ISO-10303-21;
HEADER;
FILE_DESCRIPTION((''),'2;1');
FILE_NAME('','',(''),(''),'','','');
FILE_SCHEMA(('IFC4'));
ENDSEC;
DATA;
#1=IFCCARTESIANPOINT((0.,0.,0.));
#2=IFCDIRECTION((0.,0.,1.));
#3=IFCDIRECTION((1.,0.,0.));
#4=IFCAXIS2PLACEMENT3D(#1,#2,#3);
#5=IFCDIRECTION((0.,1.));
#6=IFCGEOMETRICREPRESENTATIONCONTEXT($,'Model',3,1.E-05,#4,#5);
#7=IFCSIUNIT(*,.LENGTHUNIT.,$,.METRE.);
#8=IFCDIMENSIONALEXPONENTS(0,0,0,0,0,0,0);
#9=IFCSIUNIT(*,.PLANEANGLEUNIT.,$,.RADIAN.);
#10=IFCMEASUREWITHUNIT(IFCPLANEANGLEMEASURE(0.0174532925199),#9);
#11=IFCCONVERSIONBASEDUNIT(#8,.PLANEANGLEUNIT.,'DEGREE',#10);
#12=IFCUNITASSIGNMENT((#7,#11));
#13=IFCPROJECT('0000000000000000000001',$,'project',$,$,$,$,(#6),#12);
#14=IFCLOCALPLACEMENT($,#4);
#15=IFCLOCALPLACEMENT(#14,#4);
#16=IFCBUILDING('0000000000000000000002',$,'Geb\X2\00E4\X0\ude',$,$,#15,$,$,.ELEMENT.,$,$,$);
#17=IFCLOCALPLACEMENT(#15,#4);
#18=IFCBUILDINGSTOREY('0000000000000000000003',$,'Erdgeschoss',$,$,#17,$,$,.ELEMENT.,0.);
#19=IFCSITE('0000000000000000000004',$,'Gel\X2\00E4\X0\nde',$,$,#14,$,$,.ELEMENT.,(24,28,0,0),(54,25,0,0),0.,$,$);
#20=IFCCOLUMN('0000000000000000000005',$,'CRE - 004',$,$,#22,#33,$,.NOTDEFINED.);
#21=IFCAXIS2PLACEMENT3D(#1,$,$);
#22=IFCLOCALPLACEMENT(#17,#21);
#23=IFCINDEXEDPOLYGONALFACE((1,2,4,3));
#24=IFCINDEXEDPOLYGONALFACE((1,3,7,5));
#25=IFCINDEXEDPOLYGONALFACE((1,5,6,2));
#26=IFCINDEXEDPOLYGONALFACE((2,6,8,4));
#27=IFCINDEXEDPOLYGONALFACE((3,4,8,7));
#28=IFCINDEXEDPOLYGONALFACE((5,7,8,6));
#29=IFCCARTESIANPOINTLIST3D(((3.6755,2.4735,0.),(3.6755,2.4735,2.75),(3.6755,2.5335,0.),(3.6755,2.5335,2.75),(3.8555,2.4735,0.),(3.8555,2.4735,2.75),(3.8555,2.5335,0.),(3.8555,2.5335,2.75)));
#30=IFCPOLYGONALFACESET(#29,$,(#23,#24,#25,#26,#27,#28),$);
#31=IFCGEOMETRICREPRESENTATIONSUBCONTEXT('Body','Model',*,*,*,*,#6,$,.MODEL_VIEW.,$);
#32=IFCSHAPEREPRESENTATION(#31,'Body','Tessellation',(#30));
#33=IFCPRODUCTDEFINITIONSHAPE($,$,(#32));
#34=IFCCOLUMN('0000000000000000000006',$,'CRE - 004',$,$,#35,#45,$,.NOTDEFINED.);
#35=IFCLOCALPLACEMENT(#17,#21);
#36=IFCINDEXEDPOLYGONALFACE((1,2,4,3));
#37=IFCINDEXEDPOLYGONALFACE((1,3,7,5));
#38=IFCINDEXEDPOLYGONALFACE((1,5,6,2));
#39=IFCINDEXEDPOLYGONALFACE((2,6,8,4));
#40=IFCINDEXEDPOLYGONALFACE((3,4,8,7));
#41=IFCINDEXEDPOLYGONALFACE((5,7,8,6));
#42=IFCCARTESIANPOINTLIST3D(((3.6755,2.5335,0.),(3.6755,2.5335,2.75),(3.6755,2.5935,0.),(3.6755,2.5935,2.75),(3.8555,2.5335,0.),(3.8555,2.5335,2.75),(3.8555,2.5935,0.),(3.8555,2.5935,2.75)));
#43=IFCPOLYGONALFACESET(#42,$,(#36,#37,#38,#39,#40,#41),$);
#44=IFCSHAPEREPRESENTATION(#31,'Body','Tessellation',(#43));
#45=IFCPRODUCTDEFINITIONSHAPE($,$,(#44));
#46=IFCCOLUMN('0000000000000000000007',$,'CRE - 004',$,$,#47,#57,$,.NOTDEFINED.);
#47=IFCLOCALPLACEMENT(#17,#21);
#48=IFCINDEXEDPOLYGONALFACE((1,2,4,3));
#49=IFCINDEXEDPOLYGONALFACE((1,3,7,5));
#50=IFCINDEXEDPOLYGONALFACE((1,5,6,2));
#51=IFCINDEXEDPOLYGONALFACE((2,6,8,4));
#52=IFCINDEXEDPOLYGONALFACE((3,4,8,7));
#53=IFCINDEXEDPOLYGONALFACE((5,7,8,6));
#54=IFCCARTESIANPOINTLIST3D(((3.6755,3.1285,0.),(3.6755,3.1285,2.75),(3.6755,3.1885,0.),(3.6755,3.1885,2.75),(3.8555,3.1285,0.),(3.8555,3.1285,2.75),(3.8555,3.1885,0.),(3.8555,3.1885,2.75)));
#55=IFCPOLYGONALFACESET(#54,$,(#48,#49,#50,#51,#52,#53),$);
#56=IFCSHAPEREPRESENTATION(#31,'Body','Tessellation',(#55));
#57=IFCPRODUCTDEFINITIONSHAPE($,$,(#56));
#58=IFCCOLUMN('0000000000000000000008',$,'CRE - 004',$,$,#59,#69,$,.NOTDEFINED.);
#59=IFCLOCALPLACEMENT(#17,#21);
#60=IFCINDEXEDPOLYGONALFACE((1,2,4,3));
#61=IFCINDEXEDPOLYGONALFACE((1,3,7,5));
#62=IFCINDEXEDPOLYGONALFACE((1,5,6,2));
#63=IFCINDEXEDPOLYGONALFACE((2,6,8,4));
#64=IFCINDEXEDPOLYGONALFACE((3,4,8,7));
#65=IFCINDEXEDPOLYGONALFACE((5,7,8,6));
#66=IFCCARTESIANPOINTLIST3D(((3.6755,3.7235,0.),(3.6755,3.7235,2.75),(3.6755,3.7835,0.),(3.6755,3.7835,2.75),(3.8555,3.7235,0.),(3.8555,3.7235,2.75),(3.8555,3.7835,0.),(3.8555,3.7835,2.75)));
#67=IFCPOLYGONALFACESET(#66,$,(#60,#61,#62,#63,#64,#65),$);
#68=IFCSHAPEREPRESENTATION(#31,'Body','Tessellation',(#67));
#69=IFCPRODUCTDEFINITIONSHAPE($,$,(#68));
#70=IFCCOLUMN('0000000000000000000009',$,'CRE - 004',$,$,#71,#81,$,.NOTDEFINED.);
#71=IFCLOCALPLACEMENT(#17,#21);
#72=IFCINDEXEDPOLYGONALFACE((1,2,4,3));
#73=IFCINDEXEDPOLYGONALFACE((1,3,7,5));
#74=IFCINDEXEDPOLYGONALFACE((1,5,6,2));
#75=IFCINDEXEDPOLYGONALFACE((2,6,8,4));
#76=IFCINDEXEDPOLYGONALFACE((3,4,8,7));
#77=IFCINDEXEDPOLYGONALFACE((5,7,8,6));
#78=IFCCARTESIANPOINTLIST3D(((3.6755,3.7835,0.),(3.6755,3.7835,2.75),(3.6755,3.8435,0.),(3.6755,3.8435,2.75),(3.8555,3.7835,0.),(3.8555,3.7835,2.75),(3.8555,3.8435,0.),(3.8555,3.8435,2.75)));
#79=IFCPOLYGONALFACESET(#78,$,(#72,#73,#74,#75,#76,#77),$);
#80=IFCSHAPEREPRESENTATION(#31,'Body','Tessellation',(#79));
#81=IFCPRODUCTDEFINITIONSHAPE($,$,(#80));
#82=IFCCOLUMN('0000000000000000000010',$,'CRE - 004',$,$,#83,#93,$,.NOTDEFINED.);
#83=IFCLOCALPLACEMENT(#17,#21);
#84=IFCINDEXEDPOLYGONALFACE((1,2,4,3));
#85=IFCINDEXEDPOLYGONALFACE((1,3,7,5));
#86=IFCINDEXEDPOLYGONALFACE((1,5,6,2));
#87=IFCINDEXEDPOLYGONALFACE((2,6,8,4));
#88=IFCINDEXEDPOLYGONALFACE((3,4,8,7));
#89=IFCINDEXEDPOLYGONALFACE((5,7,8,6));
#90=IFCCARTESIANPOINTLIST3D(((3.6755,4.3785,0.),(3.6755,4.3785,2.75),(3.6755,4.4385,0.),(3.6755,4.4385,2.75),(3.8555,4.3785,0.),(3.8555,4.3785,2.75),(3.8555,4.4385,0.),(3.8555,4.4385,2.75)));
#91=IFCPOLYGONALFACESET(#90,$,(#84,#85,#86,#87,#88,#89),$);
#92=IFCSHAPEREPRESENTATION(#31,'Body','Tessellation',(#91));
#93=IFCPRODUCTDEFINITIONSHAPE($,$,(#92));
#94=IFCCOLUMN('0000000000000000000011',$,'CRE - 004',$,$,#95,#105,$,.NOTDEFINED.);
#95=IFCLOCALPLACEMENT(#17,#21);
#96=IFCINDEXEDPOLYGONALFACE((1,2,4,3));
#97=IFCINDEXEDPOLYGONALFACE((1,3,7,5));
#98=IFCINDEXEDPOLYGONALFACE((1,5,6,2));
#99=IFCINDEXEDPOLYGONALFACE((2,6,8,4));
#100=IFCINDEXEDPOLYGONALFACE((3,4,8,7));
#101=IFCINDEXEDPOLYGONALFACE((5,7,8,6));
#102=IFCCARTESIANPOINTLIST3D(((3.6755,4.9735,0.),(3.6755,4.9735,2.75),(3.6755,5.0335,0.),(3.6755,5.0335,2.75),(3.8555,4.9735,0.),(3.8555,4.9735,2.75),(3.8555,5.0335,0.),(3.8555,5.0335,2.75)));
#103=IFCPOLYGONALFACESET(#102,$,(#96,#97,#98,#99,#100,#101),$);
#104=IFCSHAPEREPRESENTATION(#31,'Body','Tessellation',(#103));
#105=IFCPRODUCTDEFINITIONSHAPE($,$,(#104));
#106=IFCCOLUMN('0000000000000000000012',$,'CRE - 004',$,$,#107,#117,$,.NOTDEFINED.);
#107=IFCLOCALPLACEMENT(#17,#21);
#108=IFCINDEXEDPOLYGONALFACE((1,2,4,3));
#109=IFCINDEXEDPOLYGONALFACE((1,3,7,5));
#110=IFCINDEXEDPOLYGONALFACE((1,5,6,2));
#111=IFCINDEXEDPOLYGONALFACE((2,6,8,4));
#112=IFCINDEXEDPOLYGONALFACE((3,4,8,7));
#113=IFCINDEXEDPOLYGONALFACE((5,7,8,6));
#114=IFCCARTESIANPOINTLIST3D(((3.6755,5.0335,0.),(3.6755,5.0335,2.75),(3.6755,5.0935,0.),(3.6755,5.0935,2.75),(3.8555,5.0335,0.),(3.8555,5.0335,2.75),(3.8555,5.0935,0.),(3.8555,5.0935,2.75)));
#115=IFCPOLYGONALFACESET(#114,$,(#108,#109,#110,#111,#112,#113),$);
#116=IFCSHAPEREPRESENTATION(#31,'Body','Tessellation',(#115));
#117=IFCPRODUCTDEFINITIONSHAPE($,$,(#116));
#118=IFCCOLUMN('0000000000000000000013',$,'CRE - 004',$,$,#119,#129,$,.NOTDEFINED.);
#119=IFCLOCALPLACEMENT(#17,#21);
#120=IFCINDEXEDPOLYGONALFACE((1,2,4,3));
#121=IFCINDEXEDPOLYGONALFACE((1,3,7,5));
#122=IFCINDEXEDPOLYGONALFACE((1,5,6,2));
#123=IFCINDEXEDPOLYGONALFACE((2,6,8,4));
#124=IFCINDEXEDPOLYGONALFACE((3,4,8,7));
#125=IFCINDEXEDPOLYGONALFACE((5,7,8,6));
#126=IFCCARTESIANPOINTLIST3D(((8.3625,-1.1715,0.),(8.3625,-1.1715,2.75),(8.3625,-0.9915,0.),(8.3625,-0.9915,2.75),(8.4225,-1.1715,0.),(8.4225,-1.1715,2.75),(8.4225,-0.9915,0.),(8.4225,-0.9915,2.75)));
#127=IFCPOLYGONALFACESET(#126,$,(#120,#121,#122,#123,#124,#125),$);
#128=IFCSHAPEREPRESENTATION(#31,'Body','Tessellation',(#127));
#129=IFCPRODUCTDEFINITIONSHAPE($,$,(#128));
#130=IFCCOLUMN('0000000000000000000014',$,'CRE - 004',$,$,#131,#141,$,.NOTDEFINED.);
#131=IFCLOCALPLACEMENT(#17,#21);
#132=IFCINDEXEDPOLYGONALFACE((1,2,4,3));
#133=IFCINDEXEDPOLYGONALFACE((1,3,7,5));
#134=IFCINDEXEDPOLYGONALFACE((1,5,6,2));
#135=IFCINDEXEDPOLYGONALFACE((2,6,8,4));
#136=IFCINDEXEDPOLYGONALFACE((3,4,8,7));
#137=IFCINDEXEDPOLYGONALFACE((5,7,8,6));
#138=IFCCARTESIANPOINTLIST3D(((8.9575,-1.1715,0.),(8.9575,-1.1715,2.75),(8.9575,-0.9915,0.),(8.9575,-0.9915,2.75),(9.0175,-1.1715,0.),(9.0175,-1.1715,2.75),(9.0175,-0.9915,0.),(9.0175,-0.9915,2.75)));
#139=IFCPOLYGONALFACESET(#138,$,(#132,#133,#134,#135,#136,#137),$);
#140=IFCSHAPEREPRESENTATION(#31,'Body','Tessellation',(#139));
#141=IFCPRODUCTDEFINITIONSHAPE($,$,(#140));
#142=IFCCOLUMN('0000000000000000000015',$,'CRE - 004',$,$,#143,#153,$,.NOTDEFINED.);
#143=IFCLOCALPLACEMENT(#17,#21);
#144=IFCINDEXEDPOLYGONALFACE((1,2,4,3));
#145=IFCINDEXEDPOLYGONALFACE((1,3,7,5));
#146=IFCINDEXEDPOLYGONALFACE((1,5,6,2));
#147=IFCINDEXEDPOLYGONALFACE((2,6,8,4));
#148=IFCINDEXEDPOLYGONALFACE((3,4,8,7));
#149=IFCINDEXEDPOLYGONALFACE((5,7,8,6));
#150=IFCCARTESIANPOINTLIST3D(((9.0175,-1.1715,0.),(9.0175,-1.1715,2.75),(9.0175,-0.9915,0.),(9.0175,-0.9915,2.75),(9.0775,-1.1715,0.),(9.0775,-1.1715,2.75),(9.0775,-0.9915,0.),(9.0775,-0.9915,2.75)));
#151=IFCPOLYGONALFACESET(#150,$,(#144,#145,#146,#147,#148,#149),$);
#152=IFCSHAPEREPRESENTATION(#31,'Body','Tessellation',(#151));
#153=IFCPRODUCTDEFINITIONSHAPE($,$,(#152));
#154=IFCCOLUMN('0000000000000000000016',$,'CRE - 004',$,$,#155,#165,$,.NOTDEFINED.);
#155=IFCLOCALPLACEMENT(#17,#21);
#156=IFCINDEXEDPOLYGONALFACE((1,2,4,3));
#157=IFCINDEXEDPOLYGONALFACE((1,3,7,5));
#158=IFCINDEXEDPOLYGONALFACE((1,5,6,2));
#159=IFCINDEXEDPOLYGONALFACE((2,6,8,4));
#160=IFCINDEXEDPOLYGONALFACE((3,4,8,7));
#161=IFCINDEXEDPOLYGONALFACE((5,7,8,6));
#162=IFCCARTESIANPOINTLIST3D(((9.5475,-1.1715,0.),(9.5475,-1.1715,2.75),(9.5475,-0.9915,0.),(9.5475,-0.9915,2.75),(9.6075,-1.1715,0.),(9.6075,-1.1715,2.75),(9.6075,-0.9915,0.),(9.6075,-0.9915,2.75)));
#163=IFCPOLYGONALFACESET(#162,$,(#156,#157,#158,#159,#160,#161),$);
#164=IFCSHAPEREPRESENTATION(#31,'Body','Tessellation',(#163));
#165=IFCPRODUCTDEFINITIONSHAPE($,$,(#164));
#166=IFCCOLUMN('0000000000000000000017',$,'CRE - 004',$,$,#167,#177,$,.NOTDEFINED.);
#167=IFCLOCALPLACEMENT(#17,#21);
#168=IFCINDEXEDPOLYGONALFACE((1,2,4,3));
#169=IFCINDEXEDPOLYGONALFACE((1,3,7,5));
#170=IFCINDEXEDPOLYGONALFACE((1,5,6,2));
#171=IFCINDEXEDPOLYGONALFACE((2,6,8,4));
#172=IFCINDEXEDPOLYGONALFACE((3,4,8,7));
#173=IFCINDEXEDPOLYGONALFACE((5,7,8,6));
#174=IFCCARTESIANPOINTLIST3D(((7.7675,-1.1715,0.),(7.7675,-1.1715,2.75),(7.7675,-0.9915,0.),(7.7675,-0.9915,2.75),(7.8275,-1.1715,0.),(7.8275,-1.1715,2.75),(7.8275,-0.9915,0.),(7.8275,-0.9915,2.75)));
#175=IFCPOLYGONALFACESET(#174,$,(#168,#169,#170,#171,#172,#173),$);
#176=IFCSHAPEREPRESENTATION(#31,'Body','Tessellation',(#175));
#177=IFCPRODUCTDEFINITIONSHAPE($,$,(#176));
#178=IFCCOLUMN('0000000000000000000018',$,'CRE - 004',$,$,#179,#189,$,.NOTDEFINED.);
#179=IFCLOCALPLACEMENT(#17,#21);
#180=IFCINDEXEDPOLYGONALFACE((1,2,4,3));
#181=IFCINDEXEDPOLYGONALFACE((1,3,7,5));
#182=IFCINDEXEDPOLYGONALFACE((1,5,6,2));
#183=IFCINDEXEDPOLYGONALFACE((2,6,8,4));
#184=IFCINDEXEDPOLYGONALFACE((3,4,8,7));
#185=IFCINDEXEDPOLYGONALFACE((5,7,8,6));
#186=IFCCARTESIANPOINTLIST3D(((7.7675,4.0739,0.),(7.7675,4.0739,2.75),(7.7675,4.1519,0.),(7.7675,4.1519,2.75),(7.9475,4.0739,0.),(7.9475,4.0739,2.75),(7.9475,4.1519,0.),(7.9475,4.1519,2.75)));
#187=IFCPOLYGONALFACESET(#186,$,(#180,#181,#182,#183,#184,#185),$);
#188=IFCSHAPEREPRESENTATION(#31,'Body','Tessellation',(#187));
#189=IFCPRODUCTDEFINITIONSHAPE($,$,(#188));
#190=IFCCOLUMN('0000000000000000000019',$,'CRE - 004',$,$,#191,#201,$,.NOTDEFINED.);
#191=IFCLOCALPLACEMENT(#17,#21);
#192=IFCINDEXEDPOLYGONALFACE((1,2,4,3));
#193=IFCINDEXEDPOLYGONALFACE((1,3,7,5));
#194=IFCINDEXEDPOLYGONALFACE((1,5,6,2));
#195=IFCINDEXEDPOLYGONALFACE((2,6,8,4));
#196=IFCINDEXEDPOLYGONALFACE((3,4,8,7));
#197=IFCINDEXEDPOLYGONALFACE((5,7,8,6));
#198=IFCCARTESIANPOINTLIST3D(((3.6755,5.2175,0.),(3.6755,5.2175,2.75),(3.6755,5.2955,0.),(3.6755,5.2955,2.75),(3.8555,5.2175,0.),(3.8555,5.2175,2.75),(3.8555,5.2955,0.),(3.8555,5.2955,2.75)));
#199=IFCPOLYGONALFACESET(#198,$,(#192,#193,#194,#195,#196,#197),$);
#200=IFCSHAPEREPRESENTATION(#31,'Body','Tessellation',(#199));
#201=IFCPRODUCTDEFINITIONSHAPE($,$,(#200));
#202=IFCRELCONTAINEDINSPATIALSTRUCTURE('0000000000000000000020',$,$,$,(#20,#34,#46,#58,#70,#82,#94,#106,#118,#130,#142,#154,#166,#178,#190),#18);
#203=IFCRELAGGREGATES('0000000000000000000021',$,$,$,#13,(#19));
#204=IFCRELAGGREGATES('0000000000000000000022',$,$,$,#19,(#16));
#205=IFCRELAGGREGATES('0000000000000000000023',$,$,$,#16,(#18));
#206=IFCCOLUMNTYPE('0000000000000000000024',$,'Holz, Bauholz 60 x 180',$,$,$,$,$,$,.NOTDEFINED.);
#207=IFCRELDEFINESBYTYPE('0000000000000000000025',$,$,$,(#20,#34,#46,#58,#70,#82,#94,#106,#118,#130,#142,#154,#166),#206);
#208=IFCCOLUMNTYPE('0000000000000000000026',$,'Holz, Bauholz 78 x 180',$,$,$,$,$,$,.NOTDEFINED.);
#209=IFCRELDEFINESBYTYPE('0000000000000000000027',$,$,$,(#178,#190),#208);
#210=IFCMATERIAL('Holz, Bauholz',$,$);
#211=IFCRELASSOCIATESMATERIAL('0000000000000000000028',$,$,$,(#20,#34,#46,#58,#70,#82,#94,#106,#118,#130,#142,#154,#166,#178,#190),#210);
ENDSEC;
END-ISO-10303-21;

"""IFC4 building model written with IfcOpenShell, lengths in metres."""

from ifc_helpers import new_model, entity, si_unit, converted_unit, direction, frame, origin_with_axes, origin_2d_with_axis, place, context, subcontext, project, spatial, rectangle, extrude, material, type_object, element, save


model = new_model("IFC4")

# Units and contexts
model_context = context("Model", 3, precision=1e-05, world=origin_with_axes(), true_north=direction((0.0, 1.0)))
body_context = subcontext(model_context, "Body", "Model", "MODEL_VIEW")
ifc_project = project(units=[si_unit("LENGTHUNIT", "METRE"), converted_unit("PLANEANGLEUNIT", "DEGREE", entity("IfcPlaneAngleMeasure", 0.0174532925199), si_unit("PLANEANGLEUNIT", "RADIAN"), dimensions=[0, 0, 0, 0, 0, 0, 0])], contexts=[model_context])

# Site, building, storey
site_placement = place(None, origin_with_axes())
site = spatial("IfcSite", under=ifc_project, at=site_placement, Name="Gelände", CompositionType="ELEMENT", RefLatitude=(24, 28, 0, 0), RefLongitude=(54, 25, 0, 0), RefElevation=0.0)
building_placement = place(site_placement, origin_with_axes())
building = spatial("IfcBuilding", under=site, at=building_placement, Name="Gebäude", CompositionType="ELEMENT")
storey_placement = place(building_placement, origin_with_axes())
storey = spatial("IfcBuildingStorey", under=building, at=storey_placement, Name="Erdgeschoss", CompositionType="ELEMENT", Elevation=0.0)

# Columns
ifc_material = material(Name="Holz, Bauholz")
column_type_1 = type_object("IfcColumnType", Name="Holz, Bauholz 60 x 180", PredefinedType="NOTDEFINED")
for number, where, z_axis, x_axis, name in (
    (1, (3.7655, 2.5035, 0.0), (0.0, 0.0, 1.0), (1.0, 0.0, 0.0), "CRE - 004"),
    (2, (3.7655, 2.5635, 0.0), (0.0, 0.0, 1.0), (1.0, 0.0, 0.0), "CRE - 004"),
    (3, (3.7655, 3.1585, 0.0), (0.0, 0.0, 1.0), (1.0, 0.0, 0.0), "CRE - 004"),
    (4, (3.7655, 3.7535, 0.0), (0.0, 0.0, 1.0), (1.0, 0.0, 0.0), "CRE - 004"),
    (5, (3.7655, 3.8135, 0.0), (0.0, 0.0, 1.0), (1.0, 0.0, 0.0), "CRE - 004"),
    (6, (3.7655, 4.4085, 0.0), (0.0, 0.0, 1.0), (1.0, 0.0, 0.0), "CRE - 004"),
    (7, (3.7655, 5.0035, 0.0), (0.0, 0.0, 1.0), (1.0, 0.0, 0.0), "CRE - 004"),
    (8, (3.7655, 5.0635, 0.0), (0.0, 0.0, 1.0), (1.0, 0.0, 0.0), "CRE - 004"),
    (9, (8.3925, -1.0815, 0.0), (0.0, 0.0, 1.0), (0.0, -1.0, 0.0), "CRE - 004"),
    (10, (8.9875, -1.0815, 0.0), (0.0, 0.0, 1.0), (0.0, -1.0, 0.0), "CRE - 004"),
    (11, (9.0475, -1.0815, 0.0), (0.0, 0.0, 1.0), (0.0, -1.0, 0.0), "CRE - 004"),
    (12, (9.5775, -1.0815, 0.0), (0.0, 0.0, 1.0), (0.0, -1.0, 0.0), "CRE - 004"),
    (13, (7.7975, -1.0815, 0.0), (0.0, 0.0, 1.0), (0.0, -1.0, 0.0), "CRE - 004"),
):
    element("IfcColumn", number, at=place(storey_placement, frame(where, z_axis=z_axis, x_axis=x_axis)), inside=storey, type_object=column_type_1, material=ifc_material, Name=name, PredefinedType="NOTDEFINED", context=body_context, shape_type="SweptSolid", body=[
        extrude(rectangle(XDim=0.06, YDim=0.18, at=origin_2d_with_axis()), frame((0.0, 0.0, 0.0), z_axis=(0.0, 0.0, 1.0), x_axis=(0.0, 1.0, 0.0)), (0.0, 0.0, 1.0), 2.75),
    ])
column_type_2 = type_object("IfcColumnType", Name="Holz, Bauholz 78 x 180", PredefinedType="NOTDEFINED")
for number, where, z_axis, x_axis, name in (
    (14, (7.8575, 4.1129, 0.0), (0.0, 0.0, 1.0), (1.0, 0.0, 0.0), "CRE - 004"),
    (15, (3.7655, 5.2565, 0.0), (0.0, 0.0, 1.0), (1.0, 0.0, 0.0), "CRE - 004"),
):
    element("IfcColumn", number, at=place(storey_placement, frame(where, z_axis=z_axis, x_axis=x_axis)), inside=storey, type_object=column_type_2, material=ifc_material, Name=name, PredefinedType="NOTDEFINED", context=body_context, shape_type="SweptSolid", body=[
        extrude(rectangle(XDim=0.078, YDim=0.18, at=origin_2d_with_axis()), frame((0.0, 0.0, 0.0), z_axis=(0.0, 0.0, 1.0), x_axis=(0.0, 1.0, 0.0)), (0.0, 0.0, 1.0), 2.75),
    ])

save(model, "model.ifc")
